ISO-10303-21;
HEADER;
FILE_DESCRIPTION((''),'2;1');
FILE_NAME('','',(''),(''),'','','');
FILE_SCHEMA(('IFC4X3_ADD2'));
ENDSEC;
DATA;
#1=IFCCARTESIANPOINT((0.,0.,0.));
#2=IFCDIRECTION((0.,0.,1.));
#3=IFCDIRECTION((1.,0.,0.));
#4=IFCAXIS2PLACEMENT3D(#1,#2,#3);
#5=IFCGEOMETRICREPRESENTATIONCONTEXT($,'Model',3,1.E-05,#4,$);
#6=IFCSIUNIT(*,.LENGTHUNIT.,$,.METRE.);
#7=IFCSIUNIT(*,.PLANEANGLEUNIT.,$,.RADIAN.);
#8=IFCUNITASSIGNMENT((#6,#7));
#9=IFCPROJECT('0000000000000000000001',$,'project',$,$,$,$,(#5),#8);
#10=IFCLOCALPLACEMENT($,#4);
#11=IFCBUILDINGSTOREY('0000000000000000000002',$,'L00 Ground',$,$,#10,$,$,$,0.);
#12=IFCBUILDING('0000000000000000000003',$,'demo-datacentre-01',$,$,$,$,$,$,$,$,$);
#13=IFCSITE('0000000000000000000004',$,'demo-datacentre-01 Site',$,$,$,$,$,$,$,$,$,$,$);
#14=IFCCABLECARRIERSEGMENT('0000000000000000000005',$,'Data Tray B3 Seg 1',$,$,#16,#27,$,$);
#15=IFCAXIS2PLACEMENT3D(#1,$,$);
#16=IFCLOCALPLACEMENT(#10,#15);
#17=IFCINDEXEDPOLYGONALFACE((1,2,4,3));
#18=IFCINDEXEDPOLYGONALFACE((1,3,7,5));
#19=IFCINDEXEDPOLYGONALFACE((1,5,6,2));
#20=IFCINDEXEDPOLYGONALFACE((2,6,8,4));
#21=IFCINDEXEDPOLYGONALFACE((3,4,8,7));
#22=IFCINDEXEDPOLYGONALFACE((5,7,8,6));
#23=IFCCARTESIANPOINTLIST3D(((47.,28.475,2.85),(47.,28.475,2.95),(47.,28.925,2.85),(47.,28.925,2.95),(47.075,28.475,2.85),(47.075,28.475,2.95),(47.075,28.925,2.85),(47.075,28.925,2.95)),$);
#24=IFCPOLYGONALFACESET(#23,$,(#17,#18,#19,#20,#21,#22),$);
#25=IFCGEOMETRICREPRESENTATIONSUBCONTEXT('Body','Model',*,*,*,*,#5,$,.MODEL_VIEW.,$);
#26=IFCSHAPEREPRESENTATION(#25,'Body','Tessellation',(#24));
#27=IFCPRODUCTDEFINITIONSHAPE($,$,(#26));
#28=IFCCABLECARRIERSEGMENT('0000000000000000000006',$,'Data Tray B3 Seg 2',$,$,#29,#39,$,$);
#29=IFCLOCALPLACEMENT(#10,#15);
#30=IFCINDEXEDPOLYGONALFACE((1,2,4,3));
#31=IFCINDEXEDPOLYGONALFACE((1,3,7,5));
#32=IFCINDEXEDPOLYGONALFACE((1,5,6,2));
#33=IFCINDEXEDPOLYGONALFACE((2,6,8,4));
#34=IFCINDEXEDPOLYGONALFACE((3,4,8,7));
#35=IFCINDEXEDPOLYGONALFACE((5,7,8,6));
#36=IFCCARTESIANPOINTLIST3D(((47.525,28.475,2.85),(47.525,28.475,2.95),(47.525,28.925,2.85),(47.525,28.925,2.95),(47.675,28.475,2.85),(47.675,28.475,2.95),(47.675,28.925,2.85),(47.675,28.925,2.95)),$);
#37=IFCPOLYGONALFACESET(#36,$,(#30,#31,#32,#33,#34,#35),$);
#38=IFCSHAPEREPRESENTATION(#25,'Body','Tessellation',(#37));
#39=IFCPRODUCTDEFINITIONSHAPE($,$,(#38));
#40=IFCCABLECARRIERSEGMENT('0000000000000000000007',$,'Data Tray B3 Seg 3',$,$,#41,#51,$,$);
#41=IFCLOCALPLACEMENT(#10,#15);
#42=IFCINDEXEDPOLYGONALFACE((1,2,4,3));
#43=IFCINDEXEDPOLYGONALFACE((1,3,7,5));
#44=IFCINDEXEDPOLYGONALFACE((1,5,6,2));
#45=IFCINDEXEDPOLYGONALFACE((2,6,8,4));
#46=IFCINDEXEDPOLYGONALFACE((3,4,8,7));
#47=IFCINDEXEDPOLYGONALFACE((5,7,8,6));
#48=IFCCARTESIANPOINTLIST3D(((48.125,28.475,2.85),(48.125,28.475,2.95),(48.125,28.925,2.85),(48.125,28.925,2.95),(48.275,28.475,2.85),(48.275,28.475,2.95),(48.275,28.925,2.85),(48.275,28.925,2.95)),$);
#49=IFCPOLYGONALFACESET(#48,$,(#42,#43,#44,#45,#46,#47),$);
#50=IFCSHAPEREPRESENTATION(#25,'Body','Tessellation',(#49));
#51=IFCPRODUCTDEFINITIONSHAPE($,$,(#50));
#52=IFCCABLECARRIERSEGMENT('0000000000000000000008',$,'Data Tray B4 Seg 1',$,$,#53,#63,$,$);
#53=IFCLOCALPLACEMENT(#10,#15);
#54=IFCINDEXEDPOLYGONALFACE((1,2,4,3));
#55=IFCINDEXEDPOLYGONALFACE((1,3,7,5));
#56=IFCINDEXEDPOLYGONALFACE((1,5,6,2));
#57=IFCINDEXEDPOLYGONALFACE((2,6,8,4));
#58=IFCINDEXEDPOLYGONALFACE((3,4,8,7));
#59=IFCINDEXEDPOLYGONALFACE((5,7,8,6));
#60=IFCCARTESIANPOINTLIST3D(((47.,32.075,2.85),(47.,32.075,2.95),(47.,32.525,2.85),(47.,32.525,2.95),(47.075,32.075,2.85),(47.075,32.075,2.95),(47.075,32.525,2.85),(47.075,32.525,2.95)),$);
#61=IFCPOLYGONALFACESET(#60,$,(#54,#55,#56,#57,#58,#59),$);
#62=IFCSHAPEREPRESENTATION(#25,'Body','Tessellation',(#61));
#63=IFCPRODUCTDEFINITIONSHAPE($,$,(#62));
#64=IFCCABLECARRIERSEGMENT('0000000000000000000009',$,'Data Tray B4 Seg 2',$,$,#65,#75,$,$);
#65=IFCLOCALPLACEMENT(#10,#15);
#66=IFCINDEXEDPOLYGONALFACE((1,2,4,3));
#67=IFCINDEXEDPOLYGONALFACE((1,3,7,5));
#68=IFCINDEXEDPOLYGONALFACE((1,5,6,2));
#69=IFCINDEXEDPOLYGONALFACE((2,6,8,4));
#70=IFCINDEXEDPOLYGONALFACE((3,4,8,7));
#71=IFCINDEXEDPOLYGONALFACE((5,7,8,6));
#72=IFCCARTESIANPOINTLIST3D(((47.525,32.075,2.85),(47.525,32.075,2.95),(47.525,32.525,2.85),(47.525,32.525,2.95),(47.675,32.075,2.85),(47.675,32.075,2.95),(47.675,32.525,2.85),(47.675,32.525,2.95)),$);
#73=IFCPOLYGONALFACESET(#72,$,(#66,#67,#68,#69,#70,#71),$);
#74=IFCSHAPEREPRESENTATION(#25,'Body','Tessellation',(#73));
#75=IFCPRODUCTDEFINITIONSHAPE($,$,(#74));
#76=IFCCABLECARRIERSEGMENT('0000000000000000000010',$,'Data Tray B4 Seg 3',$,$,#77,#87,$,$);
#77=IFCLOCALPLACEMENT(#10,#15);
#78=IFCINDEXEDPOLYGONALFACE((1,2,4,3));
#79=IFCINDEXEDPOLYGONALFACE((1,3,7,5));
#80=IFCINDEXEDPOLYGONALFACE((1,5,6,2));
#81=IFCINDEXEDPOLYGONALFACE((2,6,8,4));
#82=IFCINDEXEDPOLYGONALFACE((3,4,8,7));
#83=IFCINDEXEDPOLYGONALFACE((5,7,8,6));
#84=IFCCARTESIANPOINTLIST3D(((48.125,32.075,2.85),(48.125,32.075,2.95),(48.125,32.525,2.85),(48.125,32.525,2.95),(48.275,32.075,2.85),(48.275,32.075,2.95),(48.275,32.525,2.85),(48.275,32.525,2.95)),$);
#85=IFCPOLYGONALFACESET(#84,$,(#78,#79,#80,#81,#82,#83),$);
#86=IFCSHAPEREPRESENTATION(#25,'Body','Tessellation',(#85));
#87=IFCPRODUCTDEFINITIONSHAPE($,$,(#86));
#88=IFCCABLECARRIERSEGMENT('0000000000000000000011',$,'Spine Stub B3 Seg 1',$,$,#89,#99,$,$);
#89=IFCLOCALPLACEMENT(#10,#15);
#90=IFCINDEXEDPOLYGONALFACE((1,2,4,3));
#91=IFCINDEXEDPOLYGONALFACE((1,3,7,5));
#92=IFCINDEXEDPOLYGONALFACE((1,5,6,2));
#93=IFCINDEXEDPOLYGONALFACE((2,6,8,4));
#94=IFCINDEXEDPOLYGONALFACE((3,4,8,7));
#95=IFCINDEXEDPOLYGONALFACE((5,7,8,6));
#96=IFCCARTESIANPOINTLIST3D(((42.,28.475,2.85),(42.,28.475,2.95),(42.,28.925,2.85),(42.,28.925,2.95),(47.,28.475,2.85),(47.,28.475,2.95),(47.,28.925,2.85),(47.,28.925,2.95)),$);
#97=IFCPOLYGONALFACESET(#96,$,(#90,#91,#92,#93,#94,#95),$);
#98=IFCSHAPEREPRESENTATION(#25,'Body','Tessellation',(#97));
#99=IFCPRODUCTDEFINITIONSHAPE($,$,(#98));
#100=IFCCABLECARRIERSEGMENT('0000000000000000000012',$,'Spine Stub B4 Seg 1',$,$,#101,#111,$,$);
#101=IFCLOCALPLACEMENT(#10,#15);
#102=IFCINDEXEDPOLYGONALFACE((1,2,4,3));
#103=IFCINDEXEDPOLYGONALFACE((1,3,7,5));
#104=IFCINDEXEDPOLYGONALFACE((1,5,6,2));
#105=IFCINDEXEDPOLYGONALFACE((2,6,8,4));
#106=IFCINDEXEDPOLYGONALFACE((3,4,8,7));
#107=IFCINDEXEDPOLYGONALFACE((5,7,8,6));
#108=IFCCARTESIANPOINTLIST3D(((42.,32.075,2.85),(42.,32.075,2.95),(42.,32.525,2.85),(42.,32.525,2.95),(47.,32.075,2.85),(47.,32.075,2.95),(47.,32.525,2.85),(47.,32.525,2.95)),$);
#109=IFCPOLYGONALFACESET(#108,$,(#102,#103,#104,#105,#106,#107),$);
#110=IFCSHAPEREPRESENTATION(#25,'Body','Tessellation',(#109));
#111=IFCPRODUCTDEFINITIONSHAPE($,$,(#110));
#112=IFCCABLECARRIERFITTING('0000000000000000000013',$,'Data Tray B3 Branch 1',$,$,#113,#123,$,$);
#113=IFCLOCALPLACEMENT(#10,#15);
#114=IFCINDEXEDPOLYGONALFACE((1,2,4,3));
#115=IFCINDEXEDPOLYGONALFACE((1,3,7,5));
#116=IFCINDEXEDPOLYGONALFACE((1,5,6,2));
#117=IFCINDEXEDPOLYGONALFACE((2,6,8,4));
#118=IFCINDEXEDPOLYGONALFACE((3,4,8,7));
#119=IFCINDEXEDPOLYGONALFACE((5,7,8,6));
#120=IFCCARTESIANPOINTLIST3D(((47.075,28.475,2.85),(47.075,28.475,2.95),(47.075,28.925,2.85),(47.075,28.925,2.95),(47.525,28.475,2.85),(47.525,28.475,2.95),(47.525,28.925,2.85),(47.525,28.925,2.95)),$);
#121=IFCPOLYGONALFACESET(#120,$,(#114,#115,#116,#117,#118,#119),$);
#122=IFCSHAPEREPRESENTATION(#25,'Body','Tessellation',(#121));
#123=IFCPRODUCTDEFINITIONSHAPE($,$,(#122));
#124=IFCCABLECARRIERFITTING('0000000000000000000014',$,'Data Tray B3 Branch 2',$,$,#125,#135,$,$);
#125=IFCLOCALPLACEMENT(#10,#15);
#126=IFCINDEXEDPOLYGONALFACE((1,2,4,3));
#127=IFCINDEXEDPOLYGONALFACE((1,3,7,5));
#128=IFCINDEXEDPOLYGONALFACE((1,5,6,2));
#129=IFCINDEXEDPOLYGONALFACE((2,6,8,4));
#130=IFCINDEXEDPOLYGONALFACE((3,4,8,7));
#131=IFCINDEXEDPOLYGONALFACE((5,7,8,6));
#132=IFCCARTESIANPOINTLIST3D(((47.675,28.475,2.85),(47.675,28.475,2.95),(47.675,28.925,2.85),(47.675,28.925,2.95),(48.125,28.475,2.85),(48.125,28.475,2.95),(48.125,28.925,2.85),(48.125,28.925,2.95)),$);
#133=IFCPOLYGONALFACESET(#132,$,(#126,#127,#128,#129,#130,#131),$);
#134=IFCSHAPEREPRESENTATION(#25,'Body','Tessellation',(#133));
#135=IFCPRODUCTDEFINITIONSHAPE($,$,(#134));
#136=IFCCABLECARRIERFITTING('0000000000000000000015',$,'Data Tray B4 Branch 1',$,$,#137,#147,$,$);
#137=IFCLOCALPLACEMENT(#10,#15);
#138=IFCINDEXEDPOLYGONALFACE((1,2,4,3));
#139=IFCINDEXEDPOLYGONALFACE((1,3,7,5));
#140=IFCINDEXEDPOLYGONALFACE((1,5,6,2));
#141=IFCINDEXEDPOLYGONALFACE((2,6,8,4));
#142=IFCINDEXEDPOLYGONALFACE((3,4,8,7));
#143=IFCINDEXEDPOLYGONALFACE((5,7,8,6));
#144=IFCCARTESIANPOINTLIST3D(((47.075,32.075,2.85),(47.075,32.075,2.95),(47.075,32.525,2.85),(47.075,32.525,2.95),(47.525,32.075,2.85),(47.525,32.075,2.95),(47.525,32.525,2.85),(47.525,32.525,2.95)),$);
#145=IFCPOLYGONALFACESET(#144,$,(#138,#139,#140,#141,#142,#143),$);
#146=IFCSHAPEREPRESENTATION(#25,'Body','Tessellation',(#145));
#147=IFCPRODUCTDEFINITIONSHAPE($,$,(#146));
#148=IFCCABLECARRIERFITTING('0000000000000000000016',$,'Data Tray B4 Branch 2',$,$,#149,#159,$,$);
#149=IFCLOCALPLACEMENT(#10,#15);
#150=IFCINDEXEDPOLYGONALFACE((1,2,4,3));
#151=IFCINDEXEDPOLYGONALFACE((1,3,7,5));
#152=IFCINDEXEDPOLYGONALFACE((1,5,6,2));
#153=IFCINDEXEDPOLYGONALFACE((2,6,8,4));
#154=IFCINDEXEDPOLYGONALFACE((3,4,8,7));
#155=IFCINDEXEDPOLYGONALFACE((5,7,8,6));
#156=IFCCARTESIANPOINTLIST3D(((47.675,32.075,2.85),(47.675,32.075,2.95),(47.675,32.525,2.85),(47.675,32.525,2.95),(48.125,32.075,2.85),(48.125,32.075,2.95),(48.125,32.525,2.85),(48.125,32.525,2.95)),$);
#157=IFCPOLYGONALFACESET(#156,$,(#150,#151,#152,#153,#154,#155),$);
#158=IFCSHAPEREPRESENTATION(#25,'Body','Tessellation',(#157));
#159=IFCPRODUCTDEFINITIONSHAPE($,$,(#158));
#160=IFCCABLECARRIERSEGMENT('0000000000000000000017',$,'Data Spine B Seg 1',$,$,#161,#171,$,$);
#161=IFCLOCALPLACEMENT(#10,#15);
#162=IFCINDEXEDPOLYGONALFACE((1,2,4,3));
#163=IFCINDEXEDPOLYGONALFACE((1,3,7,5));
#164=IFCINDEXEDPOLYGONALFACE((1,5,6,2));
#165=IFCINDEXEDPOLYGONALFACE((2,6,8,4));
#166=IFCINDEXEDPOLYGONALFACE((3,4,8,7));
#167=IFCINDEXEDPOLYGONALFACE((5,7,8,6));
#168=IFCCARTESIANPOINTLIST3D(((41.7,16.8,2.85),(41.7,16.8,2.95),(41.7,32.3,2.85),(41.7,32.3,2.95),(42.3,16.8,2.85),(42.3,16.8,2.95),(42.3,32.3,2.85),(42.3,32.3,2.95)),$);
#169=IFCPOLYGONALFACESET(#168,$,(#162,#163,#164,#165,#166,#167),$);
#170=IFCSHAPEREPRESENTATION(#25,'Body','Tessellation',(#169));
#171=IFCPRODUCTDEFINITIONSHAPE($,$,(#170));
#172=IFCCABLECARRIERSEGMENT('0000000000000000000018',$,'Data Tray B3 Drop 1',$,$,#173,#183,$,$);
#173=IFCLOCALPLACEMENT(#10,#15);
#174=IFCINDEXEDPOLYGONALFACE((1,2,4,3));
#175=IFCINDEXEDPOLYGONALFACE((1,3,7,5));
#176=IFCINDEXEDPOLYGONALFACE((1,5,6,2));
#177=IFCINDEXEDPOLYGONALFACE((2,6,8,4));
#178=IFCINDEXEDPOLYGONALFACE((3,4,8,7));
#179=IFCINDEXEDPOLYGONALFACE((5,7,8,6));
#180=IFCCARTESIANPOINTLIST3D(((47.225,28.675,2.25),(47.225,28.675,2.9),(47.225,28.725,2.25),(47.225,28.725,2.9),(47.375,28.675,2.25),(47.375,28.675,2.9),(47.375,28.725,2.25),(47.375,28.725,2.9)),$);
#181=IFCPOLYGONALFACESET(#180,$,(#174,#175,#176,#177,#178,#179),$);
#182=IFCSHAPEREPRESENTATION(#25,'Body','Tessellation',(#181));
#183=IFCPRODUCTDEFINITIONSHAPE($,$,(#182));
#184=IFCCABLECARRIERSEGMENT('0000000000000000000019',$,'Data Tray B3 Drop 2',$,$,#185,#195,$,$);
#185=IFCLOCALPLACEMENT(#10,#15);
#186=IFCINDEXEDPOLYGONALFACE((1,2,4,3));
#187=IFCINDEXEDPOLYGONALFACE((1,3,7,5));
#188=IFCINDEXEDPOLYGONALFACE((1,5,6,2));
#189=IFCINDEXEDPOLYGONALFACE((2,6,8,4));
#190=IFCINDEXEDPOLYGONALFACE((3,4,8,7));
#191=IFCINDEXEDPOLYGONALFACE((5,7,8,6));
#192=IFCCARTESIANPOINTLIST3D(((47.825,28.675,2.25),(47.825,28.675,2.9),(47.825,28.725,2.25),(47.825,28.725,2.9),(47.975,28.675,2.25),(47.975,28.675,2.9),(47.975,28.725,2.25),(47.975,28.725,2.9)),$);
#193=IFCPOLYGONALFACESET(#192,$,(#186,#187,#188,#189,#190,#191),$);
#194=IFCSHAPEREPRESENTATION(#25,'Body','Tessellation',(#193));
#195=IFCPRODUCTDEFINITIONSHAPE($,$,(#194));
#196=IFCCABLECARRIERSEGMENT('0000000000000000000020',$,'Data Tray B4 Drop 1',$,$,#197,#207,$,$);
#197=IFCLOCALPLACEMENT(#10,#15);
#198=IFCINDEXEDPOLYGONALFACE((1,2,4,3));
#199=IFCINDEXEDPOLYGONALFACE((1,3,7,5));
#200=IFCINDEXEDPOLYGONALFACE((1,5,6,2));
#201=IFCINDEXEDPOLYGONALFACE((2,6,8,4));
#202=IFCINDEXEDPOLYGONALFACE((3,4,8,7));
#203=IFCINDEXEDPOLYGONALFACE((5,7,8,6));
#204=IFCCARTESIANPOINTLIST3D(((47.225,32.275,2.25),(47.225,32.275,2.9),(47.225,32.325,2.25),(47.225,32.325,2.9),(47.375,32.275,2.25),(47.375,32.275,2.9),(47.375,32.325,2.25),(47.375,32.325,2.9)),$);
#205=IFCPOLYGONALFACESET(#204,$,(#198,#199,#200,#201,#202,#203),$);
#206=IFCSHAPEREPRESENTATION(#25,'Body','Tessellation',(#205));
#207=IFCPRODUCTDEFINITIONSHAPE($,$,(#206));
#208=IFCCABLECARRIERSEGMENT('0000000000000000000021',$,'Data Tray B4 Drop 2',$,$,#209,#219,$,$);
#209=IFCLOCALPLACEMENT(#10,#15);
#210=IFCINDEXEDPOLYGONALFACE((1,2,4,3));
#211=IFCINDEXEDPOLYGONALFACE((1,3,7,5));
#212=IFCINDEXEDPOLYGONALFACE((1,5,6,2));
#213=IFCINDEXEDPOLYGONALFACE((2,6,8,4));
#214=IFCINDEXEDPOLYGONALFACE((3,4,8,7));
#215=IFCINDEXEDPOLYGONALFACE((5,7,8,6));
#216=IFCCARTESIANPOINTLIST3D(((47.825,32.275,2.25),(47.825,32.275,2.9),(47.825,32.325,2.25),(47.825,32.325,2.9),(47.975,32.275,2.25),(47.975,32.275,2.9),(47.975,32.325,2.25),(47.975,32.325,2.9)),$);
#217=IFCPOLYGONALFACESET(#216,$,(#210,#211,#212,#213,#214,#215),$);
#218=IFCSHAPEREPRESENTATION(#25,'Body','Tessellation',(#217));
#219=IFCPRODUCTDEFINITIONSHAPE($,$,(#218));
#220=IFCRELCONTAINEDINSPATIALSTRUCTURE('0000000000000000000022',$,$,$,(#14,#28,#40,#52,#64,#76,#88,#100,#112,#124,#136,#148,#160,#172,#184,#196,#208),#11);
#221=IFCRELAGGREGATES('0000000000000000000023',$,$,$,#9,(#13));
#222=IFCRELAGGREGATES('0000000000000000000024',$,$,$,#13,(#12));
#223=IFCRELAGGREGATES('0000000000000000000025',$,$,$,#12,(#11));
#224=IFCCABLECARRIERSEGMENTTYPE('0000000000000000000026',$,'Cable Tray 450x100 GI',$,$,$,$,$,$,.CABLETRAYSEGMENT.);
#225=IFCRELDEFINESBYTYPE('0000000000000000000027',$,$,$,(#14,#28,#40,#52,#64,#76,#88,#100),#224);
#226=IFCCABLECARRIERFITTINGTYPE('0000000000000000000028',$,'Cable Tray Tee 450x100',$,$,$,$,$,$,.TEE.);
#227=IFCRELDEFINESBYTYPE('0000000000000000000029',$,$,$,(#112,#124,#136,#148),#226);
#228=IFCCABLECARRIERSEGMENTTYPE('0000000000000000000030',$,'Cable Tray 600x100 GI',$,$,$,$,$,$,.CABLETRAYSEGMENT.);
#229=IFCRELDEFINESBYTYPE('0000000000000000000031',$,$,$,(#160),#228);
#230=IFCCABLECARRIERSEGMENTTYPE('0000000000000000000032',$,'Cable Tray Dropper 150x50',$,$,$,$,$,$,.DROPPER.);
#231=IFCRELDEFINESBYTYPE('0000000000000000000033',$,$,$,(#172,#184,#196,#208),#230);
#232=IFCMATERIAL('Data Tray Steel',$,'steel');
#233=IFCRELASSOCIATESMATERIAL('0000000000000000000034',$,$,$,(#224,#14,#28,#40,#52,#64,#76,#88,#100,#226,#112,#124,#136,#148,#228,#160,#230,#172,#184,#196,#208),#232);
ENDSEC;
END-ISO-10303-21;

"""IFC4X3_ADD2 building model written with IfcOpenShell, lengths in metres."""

from ifc_helpers import new_model, si_unit, frame, origin_with_axes, place, context, subcontext, project, spatial, rectangle, extrude, material, type_object, element, save


model = new_model("IFC4X3_ADD2")

# Units and contexts
model_context = context("Model", 3, precision=1e-05, world=origin_with_axes())
body_context = subcontext(model_context, "Body", "Model", "MODEL_VIEW")
ifc_project = project(units=[si_unit("LENGTHUNIT", "METRE"), si_unit("PLANEANGLEUNIT", "RADIAN")], contexts=[model_context])

# Site, building, storey
site = spatial("IfcSite", under=ifc_project, Name="demo-datacentre-01 Site")
building = spatial("IfcBuilding", under=site, Name="demo-datacentre-01")
storey_placement = place(None, origin_with_axes())
storey = spatial("IfcBuildingStorey", under=building, at=storey_placement, Name="L00 Ground", Elevation=0.0)

# Cable carrier segments
ifc_material_1 = material(Name="Data Tray Steel", Category="steel")
cable_carrier_segment_type_1 = type_object("IfcCableCarrierSegmentType", Name="Cable Tray 450x100 GI", PredefinedType="CABLETRAYSEGMENT", material=ifc_material_1)
cable_carrier_segment_1_placement = place(storey_placement, frame((47.0, 28.7, 2.9), z_axis=(1.0, 0.0, 0.0), x_axis=(0.0, 1.0, 0.0)))
element("IfcCableCarrierSegment", 1, at=cable_carrier_segment_1_placement, inside=storey, type_object=cable_carrier_segment_type_1, material=ifc_material_1, Name="Data Tray B3 Seg 1", context=body_context, shape_type="SweptSolid", body=[
    extrude(rectangle(XDim=0.45, YDim=0.1), origin_with_axes(), (0.0, 0.0, 1.0), 0.075),
])
for number, where, z_axis, x_axis, name in (
    (2, (47.525, 28.7, 2.9), (1.0, 0.0, 0.0), (0.0, 1.0, 0.0), "Data Tray B3 Seg 2"),
    (3, (48.125, 28.7, 2.9), (1.0, 0.0, 0.0), (0.0, 1.0, 0.0), "Data Tray B3 Seg 3"),
):
    element("IfcCableCarrierSegment", number, at=place(storey_placement, frame(where, z_axis=z_axis, x_axis=x_axis)), inside=storey, type_object=cable_carrier_segment_type_1, material=ifc_material_1, Name=name, context=body_context, shape_type="SweptSolid", body=[
        extrude(rectangle(XDim=0.45, YDim=0.1), origin_with_axes(), (0.0, 0.0, 1.0), 0.15),
    ])
cable_carrier_segment_2_placement = place(storey_placement, frame((47.0, 32.3, 2.9), z_axis=(1.0, 0.0, 0.0), x_axis=(0.0, 1.0, 0.0)))
element("IfcCableCarrierSegment", 4, at=cable_carrier_segment_2_placement, inside=storey, type_object=cable_carrier_segment_type_1, material=ifc_material_1, Name="Data Tray B4 Seg 1", context=body_context, shape_type="SweptSolid", body=[
    extrude(rectangle(XDim=0.45, YDim=0.1), origin_with_axes(), (0.0, 0.0, 1.0), 0.075),
])
for number, where, z_axis, x_axis, name in (
    (5, (47.525, 32.3, 2.9), (1.0, 0.0, 0.0), (0.0, 1.0, 0.0), "Data Tray B4 Seg 2"),
    (6, (48.125, 32.3, 2.9), (1.0, 0.0, 0.0), (0.0, 1.0, 0.0), "Data Tray B4 Seg 3"),
):
    element("IfcCableCarrierSegment", number, at=place(storey_placement, frame(where, z_axis=z_axis, x_axis=x_axis)), inside=storey, type_object=cable_carrier_segment_type_1, material=ifc_material_1, Name=name, context=body_context, shape_type="SweptSolid", body=[
        extrude(rectangle(XDim=0.45, YDim=0.1), origin_with_axes(), (0.0, 0.0, 1.0), 0.15),
    ])
for number, where, z_axis, x_axis, name in (
    (7, (42.0, 28.7, 2.9), (1.0, 0.0, 0.0), (0.0, 1.0, 0.0), "Spine Stub B3 Seg 1"),
    (8, (42.0, 32.3, 2.9), (1.0, 0.0, 0.0), (0.0, 1.0, 0.0), "Spine Stub B4 Seg 1"),
):
    element("IfcCableCarrierSegment", number, at=place(storey_placement, frame(where, z_axis=z_axis, x_axis=x_axis)), inside=storey, type_object=cable_carrier_segment_type_1, material=ifc_material_1, Name=name, context=body_context, shape_type="SweptSolid", body=[
        extrude(rectangle(XDim=0.45, YDim=0.1), origin_with_axes(), (0.0, 0.0, 1.0), 5.0),
    ])

# Cable carrier fittings
cable_carrier_fitting_type = type_object("IfcCableCarrierFittingType", Name="Cable Tray Tee 450x100", PredefinedType="TEE", material=ifc_material_1)
for number, where, z_axis, x_axis, name in (
    (9, (47.3, 28.7, 2.85), (0.0, 0.0, 1.0), (1.0, 0.0, 0.0), "Data Tray B3 Branch 1"),
    (10, (47.9, 28.7, 2.85), (0.0, 0.0, 1.0), (1.0, 0.0, 0.0), "Data Tray B3 Branch 2"),
    (11, (47.3, 32.3, 2.85), (0.0, 0.0, 1.0), (1.0, 0.0, 0.0), "Data Tray B4 Branch 1"),
    (12, (47.9, 32.3, 2.85), (0.0, 0.0, 1.0), (1.0, 0.0, 0.0), "Data Tray B4 Branch 2"),
):
    element("IfcCableCarrierFitting", number, at=place(storey_placement, frame(where, z_axis=z_axis, x_axis=x_axis)), inside=storey, type_object=cable_carrier_fitting_type, material=ifc_material_1, Name=name, context=body_context, shape_type="SweptSolid", body=[
        extrude(rectangle(XDim=0.45, YDim=0.45), origin_with_axes(), (0.0, 0.0, 1.0), 0.1),
    ])

# Cable carrier segments
cable_carrier_segment_type_2 = type_object("IfcCableCarrierSegmentType", Name="Cable Tray 600x100 GI", PredefinedType="CABLETRAYSEGMENT", material=ifc_material_1)
cable_carrier_segment_3_placement = place(storey_placement, frame((42.0, 32.3, 2.9), z_axis=(0.0, -1.0, 0.0), x_axis=(1.0, 0.0, 0.0)))
element("IfcCableCarrierSegment", 13, at=cable_carrier_segment_3_placement, inside=storey, type_object=cable_carrier_segment_type_2, material=ifc_material_1, Name="Data Spine B Seg 1", context=body_context, shape_type="SweptSolid", body=[
    extrude(rectangle(XDim=0.6, YDim=0.1), origin_with_axes(), (0.0, 0.0, 1.0), 15.5),
])
cable_carrier_segment_type_3 = type_object("IfcCableCarrierSegmentType", Name="Cable Tray Dropper 150x50", PredefinedType="DROPPER", material=ifc_material_1)
for number, where, z_axis, x_axis, name in (
    (14, (47.3, 28.7, 2.9), (0.0, 0.0, -1.0), (1.0, 0.0, 0.0), "Data Tray B3 Drop 1"),
    (15, (47.9, 28.7, 2.9), (0.0, 0.0, -1.0), (1.0, 0.0, 0.0), "Data Tray B3 Drop 2"),
    (16, (47.3, 32.3, 2.9), (0.0, 0.0, -1.0), (1.0, 0.0, 0.0), "Data Tray B4 Drop 1"),
    (17, (47.9, 32.3, 2.9), (0.0, 0.0, -1.0), (1.0, 0.0, 0.0), "Data Tray B4 Drop 2"),
):
    element("IfcCableCarrierSegment", number, at=place(storey_placement, frame(where, z_axis=z_axis, x_axis=x_axis)), inside=storey, type_object=cable_carrier_segment_type_3, material=ifc_material_1, Name=name, context=body_context, shape_type="SweptSolid", body=[
        extrude(rectangle(XDim=0.15, YDim=0.05), origin_with_axes(), (0.0, 0.0, 1.0), 0.65),
    ])

save(model, "model.ifc")
